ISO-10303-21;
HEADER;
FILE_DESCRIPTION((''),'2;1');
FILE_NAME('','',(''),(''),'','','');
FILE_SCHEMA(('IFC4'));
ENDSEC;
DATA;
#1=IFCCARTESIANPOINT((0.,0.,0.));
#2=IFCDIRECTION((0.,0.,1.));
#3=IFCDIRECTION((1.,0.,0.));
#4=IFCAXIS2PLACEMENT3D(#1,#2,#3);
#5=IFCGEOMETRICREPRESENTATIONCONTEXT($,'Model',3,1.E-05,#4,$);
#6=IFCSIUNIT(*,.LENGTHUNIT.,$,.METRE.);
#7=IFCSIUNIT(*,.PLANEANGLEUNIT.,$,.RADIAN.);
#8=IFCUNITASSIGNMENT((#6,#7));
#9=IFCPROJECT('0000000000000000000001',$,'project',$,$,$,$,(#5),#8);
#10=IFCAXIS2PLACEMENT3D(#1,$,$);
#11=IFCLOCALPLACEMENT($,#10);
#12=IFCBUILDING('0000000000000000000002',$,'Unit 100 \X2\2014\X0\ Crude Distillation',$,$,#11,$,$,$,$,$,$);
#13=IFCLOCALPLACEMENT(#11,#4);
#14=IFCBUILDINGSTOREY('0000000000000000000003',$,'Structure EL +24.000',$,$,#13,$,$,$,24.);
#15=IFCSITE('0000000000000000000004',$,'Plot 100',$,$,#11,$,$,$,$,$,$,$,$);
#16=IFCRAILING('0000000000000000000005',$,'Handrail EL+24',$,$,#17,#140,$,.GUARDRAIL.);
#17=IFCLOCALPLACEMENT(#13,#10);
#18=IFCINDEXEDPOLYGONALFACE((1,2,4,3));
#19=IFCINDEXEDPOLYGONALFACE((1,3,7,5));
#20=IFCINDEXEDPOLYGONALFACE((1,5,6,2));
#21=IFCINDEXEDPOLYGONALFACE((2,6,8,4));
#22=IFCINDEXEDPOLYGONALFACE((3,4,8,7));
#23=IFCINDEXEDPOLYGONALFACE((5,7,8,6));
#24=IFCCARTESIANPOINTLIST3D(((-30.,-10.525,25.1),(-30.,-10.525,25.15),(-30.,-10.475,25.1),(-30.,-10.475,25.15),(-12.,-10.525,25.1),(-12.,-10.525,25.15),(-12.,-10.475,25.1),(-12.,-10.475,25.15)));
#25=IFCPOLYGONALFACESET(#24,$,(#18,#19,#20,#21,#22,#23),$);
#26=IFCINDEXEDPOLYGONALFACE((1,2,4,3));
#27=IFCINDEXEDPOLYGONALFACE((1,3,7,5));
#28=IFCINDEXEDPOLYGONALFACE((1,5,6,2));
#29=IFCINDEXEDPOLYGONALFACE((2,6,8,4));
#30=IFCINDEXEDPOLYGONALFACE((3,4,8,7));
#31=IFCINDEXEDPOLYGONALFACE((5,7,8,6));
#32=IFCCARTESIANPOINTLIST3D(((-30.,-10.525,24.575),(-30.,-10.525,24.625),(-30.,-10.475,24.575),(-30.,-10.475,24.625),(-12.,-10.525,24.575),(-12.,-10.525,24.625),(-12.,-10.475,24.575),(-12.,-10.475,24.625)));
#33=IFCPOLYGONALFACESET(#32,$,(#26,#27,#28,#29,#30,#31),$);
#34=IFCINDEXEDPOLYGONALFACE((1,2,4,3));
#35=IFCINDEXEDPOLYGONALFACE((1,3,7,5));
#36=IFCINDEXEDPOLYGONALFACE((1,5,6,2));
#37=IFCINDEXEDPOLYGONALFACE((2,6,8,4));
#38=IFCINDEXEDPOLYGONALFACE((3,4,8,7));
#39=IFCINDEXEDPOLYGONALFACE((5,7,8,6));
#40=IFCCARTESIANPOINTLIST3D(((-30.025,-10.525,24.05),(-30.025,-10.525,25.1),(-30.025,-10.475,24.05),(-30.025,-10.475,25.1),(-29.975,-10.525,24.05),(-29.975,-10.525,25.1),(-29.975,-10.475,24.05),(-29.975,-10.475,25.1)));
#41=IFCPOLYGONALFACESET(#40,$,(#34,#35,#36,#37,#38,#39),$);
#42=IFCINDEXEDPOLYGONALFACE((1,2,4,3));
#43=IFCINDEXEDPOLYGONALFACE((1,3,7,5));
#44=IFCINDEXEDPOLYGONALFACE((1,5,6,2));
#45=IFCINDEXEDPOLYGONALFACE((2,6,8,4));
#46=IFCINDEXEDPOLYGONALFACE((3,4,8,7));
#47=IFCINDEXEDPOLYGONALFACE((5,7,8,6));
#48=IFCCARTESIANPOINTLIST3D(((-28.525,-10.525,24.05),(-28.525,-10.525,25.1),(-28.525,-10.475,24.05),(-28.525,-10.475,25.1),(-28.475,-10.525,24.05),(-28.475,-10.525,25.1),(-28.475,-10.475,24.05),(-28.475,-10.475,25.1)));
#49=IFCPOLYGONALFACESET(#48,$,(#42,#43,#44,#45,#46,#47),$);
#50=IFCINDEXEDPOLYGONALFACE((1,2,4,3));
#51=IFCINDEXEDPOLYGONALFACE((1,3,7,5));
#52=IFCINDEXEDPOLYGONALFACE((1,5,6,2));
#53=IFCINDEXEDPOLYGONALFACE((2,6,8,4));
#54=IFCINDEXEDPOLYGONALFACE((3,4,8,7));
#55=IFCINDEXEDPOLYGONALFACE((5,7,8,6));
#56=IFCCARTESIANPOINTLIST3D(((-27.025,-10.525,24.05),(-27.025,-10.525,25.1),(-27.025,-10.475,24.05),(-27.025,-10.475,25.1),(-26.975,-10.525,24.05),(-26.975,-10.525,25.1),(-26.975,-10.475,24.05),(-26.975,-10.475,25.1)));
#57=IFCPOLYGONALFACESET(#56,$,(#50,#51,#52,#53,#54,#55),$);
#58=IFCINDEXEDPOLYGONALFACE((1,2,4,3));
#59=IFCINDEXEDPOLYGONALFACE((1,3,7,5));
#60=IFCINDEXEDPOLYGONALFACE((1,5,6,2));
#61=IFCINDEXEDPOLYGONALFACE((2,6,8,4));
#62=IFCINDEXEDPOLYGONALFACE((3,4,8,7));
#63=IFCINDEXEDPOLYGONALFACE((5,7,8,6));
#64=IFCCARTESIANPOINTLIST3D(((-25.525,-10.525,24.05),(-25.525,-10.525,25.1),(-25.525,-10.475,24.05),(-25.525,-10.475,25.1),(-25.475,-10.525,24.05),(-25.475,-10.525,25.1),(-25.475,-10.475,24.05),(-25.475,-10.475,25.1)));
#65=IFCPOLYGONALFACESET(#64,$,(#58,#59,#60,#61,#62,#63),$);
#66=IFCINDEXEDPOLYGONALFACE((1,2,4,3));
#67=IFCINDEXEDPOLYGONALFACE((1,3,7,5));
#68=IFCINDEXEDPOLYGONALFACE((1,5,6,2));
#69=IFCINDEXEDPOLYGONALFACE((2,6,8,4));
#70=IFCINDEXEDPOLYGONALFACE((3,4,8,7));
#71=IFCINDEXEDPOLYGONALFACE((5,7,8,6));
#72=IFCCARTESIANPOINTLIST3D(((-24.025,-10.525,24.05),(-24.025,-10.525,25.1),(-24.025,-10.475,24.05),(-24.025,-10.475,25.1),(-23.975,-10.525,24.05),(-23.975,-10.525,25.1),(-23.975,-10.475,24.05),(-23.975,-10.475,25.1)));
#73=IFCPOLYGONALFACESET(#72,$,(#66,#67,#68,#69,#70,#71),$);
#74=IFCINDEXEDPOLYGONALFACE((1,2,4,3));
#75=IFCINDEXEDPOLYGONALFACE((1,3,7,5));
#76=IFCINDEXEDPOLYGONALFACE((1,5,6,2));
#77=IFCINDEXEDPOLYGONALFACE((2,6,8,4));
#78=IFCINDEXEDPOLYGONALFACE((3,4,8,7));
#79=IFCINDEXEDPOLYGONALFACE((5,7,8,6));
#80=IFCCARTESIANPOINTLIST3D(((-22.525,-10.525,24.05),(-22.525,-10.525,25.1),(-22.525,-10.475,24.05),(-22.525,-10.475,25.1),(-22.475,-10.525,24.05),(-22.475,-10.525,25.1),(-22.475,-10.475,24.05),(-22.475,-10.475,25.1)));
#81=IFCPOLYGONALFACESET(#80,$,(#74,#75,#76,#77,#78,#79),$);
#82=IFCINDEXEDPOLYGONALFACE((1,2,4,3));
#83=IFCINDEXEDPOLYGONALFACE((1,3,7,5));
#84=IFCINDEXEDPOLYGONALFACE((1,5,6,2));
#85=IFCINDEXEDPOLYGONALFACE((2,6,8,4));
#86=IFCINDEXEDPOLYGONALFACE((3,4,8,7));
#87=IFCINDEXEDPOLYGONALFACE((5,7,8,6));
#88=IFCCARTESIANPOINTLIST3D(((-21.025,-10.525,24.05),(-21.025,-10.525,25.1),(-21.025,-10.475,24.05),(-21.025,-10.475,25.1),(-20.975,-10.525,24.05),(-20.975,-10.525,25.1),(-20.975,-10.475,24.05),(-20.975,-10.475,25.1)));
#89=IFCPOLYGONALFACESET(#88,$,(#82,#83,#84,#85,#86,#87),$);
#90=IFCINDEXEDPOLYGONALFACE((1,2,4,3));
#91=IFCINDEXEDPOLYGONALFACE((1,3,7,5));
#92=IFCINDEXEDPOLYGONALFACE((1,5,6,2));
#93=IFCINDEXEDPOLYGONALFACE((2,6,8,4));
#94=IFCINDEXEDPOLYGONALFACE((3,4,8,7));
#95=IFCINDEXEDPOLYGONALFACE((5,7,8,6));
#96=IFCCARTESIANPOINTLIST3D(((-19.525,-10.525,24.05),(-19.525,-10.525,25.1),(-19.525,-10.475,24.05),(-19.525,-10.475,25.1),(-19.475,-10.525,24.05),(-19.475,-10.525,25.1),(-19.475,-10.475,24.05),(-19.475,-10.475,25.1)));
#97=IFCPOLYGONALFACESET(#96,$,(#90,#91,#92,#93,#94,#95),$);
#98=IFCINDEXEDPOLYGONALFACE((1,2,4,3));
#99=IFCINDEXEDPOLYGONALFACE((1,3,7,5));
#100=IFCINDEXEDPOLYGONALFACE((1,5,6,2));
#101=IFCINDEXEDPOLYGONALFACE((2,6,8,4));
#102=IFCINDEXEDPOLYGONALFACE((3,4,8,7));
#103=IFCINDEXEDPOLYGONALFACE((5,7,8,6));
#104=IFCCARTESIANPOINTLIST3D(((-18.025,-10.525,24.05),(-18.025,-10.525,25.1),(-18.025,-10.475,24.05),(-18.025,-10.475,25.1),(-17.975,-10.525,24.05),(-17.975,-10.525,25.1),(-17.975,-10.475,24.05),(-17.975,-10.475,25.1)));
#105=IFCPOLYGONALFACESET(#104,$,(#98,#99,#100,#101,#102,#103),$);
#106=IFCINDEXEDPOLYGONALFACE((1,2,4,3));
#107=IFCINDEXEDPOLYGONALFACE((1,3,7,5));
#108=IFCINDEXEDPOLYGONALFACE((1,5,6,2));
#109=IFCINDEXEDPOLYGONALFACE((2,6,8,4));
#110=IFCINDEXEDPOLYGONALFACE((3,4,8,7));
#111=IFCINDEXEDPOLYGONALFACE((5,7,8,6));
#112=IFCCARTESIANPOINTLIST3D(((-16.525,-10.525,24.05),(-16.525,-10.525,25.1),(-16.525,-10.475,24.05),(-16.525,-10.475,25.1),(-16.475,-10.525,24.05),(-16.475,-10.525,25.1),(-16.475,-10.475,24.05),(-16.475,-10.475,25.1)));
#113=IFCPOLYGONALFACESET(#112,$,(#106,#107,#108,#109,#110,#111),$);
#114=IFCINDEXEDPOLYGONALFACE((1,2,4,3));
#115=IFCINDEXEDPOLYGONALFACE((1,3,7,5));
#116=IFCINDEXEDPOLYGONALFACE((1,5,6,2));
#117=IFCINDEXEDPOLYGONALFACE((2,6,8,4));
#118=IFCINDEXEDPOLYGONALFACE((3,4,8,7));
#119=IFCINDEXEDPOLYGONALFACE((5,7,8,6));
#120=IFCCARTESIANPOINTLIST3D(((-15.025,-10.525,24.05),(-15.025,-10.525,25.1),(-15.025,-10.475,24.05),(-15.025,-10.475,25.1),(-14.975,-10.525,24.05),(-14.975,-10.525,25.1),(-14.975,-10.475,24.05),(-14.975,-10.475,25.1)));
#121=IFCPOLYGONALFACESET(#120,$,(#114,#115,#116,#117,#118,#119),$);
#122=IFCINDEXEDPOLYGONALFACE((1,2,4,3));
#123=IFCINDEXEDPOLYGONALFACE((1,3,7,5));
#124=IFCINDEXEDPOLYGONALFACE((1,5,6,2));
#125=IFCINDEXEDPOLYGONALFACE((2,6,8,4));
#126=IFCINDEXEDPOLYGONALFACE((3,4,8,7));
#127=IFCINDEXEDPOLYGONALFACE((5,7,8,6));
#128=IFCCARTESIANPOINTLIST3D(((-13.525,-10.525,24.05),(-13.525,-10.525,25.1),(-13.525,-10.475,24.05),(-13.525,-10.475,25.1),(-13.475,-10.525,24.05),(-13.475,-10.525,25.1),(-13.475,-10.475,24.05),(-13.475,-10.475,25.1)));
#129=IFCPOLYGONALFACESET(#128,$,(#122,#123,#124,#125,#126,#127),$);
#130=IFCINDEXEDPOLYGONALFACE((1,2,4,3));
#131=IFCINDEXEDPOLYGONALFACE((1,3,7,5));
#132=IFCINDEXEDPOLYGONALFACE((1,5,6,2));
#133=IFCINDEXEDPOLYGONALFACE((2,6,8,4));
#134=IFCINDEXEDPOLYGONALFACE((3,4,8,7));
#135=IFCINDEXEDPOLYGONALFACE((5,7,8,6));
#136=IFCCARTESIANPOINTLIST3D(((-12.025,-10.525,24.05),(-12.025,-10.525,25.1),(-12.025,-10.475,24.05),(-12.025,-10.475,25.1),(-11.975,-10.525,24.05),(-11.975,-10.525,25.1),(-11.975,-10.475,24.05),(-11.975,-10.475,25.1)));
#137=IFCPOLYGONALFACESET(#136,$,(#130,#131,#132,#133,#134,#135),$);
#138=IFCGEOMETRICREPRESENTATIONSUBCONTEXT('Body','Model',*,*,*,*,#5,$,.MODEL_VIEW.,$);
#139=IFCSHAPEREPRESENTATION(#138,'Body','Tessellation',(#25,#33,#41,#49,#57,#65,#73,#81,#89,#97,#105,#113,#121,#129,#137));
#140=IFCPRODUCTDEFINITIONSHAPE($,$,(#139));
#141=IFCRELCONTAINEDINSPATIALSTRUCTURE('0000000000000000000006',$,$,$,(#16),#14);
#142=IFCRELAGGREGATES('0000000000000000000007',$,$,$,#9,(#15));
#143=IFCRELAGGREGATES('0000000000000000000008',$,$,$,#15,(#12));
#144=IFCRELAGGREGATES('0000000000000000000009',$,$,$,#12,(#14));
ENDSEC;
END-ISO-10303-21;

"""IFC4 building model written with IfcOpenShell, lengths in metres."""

from ifc_helpers import new_model, si_unit, frame, origin, origin_with_axes, origin_2d, place, context, subcontext, project, spatial, rectangle, extrude, element, save


model = new_model("IFC4")

# Units and contexts
model_context = context("Model", 3, precision=1e-05, world=origin_with_axes())
body_context = subcontext(model_context, "Body", "Model", "MODEL_VIEW")
ifc_project = project(units=[si_unit("LENGTHUNIT", "METRE"), si_unit("PLANEANGLEUNIT", "RADIAN")], contexts=[model_context])

# Site, building, storey
placement = place(None, origin())
site = spatial("IfcSite", under=ifc_project, at=placement, Name="Plot 100")
building = spatial("IfcBuilding", under=site, at=placement, Name="Unit 100 — Crude Distillation")
storey_placement = place(placement, origin_with_axes())
storey = spatial("IfcBuildingStorey", under=building, at=storey_placement, Name="Structure EL +24.000", Elevation=24.0)

# Railing
railing_1_placement = place(storey_placement, origin_with_axes())
element("IfcRailing", 1, at=railing_1_placement, inside=storey, Name="Handrail EL+24", PredefinedType="GUARDRAIL", context=body_context, shape_type="SweptSolid", body=[
    extrude(rectangle(XDim=0.05, YDim=0.05, at=origin_2d()), frame((-30.0, -10.5, 25.125), z_axis=(1.0, 0.0, 0.0), x_axis=(0.0, 1.0, 0.0)), (0.0, 0.0, 1.0), 18.0),
    extrude(rectangle(XDim=0.05, YDim=0.05, at=origin_2d()), frame((-30.0, -10.5, 24.6), z_axis=(1.0, 0.0, 0.0), x_axis=(0.0, 1.0, 0.0)), (0.0, 0.0, 1.0), 18.0),
    extrude(rectangle(XDim=0.05, YDim=0.05, at=origin_2d()), frame((-30.0, -10.5, 24.05), z_axis=(0.0, 0.0, 1.0), x_axis=(1.0, 0.0, 0.0)), (0.0, 0.0, 1.0), 1.05),
    extrude(rectangle(XDim=0.05, YDim=0.05, at=origin_2d()), frame((-28.5, -10.5, 24.05), z_axis=(0.0, 0.0, 1.0), x_axis=(1.0, 0.0, 0.0)), (0.0, 0.0, 1.0), 1.05),
    extrude(rectangle(XDim=0.05, YDim=0.05, at=origin_2d()), frame((-27.0, -10.5, 24.05), z_axis=(0.0, 0.0, 1.0), x_axis=(1.0, 0.0, 0.0)), (0.0, 0.0, 1.0), 1.05),
    extrude(rectangle(XDim=0.05, YDim=0.05, at=origin_2d()), frame((-25.5, -10.5, 24.05), z_axis=(0.0, 0.0, 1.0), x_axis=(1.0, 0.0, 0.0)), (0.0, 0.0, 1.0), 1.05),
    extrude(rectangle(XDim=0.05, YDim=0.05, at=origin_2d()), frame((-24.0, -10.5, 24.05), z_axis=(0.0, 0.0, 1.0), x_axis=(1.0, 0.0, 0.0)), (0.0, 0.0, 1.0), 1.05),
    extrude(rectangle(XDim=0.05, YDim=0.05, at=origin_2d()), frame((-22.5, -10.5, 24.05), z_axis=(0.0, 0.0, 1.0), x_axis=(1.0, 0.0, 0.0)), (0.0, 0.0, 1.0), 1.05),
    extrude(rectangle(XDim=0.05, YDim=0.05, at=origin_2d()), frame((-21.0, -10.5, 24.05), z_axis=(0.0, 0.0, 1.0), x_axis=(1.0, 0.0, 0.0)), (0.0, 0.0, 1.0), 1.05),
    extrude(rectangle(XDim=0.05, YDim=0.05, at=origin_2d()), frame((-19.5, -10.5, 24.05), z_axis=(0.0, 0.0, 1.0), x_axis=(1.0, 0.0, 0.0)), (0.0, 0.0, 1.0), 1.05),
    extrude(rectangle(XDim=0.05, YDim=0.05, at=origin_2d()), frame((-18.0, -10.5, 24.05), z_axis=(0.0, 0.0, 1.0), x_axis=(1.0, 0.0, 0.0)), (0.0, 0.0, 1.0), 1.05),
    extrude(rectangle(XDim=0.05, YDim=0.05, at=origin_2d()), frame((-16.5, -10.5, 24.05), z_axis=(0.0, 0.0, 1.0), x_axis=(1.0, 0.0, 0.0)), (0.0, 0.0, 1.0), 1.05),
    extrude(rectangle(XDim=0.05, YDim=0.05, at=origin_2d()), frame((-15.0, -10.5, 24.05), z_axis=(0.0, 0.0, 1.0), x_axis=(1.0, 0.0, 0.0)), (0.0, 0.0, 1.0), 1.05),
    extrude(rectangle(XDim=0.05, YDim=0.05, at=origin_2d()), frame((-13.5, -10.5, 24.05), z_axis=(0.0, 0.0, 1.0), x_axis=(1.0, 0.0, 0.0)), (0.0, 0.0, 1.0), 1.05),
    extrude(rectangle(XDim=0.05, YDim=0.05, at=origin_2d()), frame((-12.0, -10.5, 24.05), z_axis=(0.0, 0.0, 1.0), x_axis=(1.0, 0.0, 0.0)), (0.0, 0.0, 1.0), 1.05),
])

save(model, "model.ifc")
